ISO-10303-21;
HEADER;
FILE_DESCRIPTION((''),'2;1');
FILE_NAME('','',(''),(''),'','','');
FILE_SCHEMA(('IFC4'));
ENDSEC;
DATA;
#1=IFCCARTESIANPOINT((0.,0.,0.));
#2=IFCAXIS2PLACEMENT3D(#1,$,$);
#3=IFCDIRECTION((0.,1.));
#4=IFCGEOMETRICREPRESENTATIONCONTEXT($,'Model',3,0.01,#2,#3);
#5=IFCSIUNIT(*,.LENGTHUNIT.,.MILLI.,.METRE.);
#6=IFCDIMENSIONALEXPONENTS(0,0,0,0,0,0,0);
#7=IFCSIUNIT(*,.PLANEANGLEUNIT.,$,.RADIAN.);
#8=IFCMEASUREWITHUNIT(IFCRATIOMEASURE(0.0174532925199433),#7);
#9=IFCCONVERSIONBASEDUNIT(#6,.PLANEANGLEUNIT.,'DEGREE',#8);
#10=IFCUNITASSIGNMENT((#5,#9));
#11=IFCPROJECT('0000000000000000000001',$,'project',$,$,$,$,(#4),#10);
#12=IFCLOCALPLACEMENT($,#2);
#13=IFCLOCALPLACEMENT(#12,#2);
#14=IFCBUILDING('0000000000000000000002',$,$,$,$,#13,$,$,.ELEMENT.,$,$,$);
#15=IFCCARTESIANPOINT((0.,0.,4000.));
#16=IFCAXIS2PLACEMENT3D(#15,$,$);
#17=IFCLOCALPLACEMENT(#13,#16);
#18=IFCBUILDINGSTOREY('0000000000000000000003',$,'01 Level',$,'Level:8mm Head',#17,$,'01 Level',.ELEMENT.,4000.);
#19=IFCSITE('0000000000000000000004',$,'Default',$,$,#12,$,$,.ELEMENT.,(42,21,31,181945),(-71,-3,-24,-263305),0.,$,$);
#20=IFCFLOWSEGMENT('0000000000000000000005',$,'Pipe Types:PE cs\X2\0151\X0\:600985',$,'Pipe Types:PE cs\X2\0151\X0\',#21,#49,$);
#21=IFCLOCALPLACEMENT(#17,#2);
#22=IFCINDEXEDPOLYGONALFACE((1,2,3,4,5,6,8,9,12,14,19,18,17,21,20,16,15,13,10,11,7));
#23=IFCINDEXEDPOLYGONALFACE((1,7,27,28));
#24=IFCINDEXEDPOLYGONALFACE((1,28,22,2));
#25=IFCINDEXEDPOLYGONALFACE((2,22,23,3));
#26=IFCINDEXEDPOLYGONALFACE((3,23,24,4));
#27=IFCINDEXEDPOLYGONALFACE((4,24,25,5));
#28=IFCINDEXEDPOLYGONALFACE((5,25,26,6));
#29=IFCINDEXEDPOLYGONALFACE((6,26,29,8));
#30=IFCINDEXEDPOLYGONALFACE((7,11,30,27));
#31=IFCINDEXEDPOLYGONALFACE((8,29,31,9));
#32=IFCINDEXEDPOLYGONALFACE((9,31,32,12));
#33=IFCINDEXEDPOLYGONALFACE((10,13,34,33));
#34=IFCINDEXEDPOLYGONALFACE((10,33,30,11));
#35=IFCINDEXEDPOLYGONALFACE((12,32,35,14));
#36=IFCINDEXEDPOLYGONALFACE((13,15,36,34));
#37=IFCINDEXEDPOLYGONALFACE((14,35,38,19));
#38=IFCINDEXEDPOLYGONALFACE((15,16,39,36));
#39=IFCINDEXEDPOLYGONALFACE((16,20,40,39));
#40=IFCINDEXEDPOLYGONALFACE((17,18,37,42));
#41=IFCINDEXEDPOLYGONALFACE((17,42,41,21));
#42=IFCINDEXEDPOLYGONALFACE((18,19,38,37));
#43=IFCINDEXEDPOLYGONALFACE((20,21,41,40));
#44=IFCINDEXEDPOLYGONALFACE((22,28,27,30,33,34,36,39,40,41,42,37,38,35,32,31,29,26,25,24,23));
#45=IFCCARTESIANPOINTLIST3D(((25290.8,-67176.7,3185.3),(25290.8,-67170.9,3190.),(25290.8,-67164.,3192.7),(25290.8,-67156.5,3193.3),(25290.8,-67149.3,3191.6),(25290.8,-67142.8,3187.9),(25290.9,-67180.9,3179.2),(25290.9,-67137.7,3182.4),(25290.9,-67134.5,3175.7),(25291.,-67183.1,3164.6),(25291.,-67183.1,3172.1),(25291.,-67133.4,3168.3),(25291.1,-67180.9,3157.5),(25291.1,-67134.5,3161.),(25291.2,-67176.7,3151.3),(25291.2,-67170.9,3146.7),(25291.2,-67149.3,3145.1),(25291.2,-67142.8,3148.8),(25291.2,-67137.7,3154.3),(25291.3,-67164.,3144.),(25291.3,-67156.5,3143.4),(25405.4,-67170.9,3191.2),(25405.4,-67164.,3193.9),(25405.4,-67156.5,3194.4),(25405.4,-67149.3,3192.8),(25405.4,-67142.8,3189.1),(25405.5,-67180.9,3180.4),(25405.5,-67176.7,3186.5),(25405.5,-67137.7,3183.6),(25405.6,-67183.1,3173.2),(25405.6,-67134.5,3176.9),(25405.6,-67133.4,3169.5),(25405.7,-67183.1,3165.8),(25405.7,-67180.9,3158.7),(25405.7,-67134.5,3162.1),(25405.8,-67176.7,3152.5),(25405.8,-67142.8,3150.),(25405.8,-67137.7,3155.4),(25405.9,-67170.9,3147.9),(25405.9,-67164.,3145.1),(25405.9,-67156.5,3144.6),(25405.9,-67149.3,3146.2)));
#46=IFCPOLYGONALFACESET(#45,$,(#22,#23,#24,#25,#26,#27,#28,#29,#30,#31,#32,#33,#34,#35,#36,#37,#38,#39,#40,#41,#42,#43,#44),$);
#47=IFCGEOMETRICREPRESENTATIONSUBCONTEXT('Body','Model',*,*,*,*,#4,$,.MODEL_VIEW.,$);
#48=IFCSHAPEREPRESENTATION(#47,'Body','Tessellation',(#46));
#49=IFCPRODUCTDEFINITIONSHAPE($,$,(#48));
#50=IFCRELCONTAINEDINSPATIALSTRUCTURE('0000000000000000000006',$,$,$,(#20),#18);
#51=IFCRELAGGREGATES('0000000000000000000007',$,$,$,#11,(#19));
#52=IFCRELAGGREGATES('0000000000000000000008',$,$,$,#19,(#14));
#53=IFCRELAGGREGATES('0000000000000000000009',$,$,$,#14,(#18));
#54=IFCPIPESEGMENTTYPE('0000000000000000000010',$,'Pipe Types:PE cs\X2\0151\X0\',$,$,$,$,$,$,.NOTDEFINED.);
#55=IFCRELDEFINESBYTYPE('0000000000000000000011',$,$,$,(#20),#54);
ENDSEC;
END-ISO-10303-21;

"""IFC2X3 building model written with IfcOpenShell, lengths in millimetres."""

from ifc_helpers import new_model, entity, si_unit, converted_unit, direction, frame, origin, origin_2d_with_axis, place, context, subcontext, project, spatial, circle, extrude, type_object, element, save


model = new_model("IFC2X3")

# Units and contexts
model_context = context("Model", 3, precision=0.01, world=origin(), true_north=direction((0.0, 1.0)))
body_context = subcontext(model_context, "Body", "Model", "MODEL_VIEW")
ifc_project = project(units=[si_unit("LENGTHUNIT", "METRE", prefix="MILLI"), converted_unit("PLANEANGLEUNIT", "DEGREE", entity("IfcRatioMeasure", 0.0174532925199433), si_unit("PLANEANGLEUNIT", "RADIAN"), dimensions=[0, 0, 0, 0, 0, 0, 0])], contexts=[model_context])

# Site, building, storey
site_placement = place(None, origin())
site = spatial("IfcSite", under=ifc_project, at=site_placement, Name="Default", CompositionType="ELEMENT", RefLatitude=(42, 21, 31, 181945), RefLongitude=(-71, -3, -24, -263305), RefElevation=0.0)
building_placement = place(site_placement, origin())
building = spatial("IfcBuilding", under=site, at=building_placement, CompositionType="ELEMENT")
storey_placement = place(building_placement, frame((0.0, 0.0, 4000.0)))
storey = spatial("IfcBuildingStorey", under=building, at=storey_placement, Name="01 Level", ObjectType="Level:8mm Head", LongName="01 Level", CompositionType="ELEMENT", Elevation=4000.0)

# Flow segment
pipe_segment_type = type_object("IfcPipeSegmentType", Name="Pipe Types:PE cső", PredefinedType="NOTDEFINED")
flow_segment_1_placement = place(storey_placement, frame((25289.2, -67185.0, 3141.7)))
element("IfcFlowSegment", 1, at=flow_segment_1_placement, inside=storey, type_object=pipe_segment_type, Name="Pipe Types:PE cső:600985", ObjectType="Pipe Types:PE cső", context=body_context, shape_type="SweptSolid", body=[
    extrude(circle(Radius=25.0, at=origin_2d_with_axis()), frame((1.9, 26.6, 26.6), z_axis=(0.999948, 0.000032, 0.010203), x_axis=(-0.000032, 1.0, 0.0)), (0.0, 0.0, 1.0), 114.6),
])

save(model, "model.ifc")
